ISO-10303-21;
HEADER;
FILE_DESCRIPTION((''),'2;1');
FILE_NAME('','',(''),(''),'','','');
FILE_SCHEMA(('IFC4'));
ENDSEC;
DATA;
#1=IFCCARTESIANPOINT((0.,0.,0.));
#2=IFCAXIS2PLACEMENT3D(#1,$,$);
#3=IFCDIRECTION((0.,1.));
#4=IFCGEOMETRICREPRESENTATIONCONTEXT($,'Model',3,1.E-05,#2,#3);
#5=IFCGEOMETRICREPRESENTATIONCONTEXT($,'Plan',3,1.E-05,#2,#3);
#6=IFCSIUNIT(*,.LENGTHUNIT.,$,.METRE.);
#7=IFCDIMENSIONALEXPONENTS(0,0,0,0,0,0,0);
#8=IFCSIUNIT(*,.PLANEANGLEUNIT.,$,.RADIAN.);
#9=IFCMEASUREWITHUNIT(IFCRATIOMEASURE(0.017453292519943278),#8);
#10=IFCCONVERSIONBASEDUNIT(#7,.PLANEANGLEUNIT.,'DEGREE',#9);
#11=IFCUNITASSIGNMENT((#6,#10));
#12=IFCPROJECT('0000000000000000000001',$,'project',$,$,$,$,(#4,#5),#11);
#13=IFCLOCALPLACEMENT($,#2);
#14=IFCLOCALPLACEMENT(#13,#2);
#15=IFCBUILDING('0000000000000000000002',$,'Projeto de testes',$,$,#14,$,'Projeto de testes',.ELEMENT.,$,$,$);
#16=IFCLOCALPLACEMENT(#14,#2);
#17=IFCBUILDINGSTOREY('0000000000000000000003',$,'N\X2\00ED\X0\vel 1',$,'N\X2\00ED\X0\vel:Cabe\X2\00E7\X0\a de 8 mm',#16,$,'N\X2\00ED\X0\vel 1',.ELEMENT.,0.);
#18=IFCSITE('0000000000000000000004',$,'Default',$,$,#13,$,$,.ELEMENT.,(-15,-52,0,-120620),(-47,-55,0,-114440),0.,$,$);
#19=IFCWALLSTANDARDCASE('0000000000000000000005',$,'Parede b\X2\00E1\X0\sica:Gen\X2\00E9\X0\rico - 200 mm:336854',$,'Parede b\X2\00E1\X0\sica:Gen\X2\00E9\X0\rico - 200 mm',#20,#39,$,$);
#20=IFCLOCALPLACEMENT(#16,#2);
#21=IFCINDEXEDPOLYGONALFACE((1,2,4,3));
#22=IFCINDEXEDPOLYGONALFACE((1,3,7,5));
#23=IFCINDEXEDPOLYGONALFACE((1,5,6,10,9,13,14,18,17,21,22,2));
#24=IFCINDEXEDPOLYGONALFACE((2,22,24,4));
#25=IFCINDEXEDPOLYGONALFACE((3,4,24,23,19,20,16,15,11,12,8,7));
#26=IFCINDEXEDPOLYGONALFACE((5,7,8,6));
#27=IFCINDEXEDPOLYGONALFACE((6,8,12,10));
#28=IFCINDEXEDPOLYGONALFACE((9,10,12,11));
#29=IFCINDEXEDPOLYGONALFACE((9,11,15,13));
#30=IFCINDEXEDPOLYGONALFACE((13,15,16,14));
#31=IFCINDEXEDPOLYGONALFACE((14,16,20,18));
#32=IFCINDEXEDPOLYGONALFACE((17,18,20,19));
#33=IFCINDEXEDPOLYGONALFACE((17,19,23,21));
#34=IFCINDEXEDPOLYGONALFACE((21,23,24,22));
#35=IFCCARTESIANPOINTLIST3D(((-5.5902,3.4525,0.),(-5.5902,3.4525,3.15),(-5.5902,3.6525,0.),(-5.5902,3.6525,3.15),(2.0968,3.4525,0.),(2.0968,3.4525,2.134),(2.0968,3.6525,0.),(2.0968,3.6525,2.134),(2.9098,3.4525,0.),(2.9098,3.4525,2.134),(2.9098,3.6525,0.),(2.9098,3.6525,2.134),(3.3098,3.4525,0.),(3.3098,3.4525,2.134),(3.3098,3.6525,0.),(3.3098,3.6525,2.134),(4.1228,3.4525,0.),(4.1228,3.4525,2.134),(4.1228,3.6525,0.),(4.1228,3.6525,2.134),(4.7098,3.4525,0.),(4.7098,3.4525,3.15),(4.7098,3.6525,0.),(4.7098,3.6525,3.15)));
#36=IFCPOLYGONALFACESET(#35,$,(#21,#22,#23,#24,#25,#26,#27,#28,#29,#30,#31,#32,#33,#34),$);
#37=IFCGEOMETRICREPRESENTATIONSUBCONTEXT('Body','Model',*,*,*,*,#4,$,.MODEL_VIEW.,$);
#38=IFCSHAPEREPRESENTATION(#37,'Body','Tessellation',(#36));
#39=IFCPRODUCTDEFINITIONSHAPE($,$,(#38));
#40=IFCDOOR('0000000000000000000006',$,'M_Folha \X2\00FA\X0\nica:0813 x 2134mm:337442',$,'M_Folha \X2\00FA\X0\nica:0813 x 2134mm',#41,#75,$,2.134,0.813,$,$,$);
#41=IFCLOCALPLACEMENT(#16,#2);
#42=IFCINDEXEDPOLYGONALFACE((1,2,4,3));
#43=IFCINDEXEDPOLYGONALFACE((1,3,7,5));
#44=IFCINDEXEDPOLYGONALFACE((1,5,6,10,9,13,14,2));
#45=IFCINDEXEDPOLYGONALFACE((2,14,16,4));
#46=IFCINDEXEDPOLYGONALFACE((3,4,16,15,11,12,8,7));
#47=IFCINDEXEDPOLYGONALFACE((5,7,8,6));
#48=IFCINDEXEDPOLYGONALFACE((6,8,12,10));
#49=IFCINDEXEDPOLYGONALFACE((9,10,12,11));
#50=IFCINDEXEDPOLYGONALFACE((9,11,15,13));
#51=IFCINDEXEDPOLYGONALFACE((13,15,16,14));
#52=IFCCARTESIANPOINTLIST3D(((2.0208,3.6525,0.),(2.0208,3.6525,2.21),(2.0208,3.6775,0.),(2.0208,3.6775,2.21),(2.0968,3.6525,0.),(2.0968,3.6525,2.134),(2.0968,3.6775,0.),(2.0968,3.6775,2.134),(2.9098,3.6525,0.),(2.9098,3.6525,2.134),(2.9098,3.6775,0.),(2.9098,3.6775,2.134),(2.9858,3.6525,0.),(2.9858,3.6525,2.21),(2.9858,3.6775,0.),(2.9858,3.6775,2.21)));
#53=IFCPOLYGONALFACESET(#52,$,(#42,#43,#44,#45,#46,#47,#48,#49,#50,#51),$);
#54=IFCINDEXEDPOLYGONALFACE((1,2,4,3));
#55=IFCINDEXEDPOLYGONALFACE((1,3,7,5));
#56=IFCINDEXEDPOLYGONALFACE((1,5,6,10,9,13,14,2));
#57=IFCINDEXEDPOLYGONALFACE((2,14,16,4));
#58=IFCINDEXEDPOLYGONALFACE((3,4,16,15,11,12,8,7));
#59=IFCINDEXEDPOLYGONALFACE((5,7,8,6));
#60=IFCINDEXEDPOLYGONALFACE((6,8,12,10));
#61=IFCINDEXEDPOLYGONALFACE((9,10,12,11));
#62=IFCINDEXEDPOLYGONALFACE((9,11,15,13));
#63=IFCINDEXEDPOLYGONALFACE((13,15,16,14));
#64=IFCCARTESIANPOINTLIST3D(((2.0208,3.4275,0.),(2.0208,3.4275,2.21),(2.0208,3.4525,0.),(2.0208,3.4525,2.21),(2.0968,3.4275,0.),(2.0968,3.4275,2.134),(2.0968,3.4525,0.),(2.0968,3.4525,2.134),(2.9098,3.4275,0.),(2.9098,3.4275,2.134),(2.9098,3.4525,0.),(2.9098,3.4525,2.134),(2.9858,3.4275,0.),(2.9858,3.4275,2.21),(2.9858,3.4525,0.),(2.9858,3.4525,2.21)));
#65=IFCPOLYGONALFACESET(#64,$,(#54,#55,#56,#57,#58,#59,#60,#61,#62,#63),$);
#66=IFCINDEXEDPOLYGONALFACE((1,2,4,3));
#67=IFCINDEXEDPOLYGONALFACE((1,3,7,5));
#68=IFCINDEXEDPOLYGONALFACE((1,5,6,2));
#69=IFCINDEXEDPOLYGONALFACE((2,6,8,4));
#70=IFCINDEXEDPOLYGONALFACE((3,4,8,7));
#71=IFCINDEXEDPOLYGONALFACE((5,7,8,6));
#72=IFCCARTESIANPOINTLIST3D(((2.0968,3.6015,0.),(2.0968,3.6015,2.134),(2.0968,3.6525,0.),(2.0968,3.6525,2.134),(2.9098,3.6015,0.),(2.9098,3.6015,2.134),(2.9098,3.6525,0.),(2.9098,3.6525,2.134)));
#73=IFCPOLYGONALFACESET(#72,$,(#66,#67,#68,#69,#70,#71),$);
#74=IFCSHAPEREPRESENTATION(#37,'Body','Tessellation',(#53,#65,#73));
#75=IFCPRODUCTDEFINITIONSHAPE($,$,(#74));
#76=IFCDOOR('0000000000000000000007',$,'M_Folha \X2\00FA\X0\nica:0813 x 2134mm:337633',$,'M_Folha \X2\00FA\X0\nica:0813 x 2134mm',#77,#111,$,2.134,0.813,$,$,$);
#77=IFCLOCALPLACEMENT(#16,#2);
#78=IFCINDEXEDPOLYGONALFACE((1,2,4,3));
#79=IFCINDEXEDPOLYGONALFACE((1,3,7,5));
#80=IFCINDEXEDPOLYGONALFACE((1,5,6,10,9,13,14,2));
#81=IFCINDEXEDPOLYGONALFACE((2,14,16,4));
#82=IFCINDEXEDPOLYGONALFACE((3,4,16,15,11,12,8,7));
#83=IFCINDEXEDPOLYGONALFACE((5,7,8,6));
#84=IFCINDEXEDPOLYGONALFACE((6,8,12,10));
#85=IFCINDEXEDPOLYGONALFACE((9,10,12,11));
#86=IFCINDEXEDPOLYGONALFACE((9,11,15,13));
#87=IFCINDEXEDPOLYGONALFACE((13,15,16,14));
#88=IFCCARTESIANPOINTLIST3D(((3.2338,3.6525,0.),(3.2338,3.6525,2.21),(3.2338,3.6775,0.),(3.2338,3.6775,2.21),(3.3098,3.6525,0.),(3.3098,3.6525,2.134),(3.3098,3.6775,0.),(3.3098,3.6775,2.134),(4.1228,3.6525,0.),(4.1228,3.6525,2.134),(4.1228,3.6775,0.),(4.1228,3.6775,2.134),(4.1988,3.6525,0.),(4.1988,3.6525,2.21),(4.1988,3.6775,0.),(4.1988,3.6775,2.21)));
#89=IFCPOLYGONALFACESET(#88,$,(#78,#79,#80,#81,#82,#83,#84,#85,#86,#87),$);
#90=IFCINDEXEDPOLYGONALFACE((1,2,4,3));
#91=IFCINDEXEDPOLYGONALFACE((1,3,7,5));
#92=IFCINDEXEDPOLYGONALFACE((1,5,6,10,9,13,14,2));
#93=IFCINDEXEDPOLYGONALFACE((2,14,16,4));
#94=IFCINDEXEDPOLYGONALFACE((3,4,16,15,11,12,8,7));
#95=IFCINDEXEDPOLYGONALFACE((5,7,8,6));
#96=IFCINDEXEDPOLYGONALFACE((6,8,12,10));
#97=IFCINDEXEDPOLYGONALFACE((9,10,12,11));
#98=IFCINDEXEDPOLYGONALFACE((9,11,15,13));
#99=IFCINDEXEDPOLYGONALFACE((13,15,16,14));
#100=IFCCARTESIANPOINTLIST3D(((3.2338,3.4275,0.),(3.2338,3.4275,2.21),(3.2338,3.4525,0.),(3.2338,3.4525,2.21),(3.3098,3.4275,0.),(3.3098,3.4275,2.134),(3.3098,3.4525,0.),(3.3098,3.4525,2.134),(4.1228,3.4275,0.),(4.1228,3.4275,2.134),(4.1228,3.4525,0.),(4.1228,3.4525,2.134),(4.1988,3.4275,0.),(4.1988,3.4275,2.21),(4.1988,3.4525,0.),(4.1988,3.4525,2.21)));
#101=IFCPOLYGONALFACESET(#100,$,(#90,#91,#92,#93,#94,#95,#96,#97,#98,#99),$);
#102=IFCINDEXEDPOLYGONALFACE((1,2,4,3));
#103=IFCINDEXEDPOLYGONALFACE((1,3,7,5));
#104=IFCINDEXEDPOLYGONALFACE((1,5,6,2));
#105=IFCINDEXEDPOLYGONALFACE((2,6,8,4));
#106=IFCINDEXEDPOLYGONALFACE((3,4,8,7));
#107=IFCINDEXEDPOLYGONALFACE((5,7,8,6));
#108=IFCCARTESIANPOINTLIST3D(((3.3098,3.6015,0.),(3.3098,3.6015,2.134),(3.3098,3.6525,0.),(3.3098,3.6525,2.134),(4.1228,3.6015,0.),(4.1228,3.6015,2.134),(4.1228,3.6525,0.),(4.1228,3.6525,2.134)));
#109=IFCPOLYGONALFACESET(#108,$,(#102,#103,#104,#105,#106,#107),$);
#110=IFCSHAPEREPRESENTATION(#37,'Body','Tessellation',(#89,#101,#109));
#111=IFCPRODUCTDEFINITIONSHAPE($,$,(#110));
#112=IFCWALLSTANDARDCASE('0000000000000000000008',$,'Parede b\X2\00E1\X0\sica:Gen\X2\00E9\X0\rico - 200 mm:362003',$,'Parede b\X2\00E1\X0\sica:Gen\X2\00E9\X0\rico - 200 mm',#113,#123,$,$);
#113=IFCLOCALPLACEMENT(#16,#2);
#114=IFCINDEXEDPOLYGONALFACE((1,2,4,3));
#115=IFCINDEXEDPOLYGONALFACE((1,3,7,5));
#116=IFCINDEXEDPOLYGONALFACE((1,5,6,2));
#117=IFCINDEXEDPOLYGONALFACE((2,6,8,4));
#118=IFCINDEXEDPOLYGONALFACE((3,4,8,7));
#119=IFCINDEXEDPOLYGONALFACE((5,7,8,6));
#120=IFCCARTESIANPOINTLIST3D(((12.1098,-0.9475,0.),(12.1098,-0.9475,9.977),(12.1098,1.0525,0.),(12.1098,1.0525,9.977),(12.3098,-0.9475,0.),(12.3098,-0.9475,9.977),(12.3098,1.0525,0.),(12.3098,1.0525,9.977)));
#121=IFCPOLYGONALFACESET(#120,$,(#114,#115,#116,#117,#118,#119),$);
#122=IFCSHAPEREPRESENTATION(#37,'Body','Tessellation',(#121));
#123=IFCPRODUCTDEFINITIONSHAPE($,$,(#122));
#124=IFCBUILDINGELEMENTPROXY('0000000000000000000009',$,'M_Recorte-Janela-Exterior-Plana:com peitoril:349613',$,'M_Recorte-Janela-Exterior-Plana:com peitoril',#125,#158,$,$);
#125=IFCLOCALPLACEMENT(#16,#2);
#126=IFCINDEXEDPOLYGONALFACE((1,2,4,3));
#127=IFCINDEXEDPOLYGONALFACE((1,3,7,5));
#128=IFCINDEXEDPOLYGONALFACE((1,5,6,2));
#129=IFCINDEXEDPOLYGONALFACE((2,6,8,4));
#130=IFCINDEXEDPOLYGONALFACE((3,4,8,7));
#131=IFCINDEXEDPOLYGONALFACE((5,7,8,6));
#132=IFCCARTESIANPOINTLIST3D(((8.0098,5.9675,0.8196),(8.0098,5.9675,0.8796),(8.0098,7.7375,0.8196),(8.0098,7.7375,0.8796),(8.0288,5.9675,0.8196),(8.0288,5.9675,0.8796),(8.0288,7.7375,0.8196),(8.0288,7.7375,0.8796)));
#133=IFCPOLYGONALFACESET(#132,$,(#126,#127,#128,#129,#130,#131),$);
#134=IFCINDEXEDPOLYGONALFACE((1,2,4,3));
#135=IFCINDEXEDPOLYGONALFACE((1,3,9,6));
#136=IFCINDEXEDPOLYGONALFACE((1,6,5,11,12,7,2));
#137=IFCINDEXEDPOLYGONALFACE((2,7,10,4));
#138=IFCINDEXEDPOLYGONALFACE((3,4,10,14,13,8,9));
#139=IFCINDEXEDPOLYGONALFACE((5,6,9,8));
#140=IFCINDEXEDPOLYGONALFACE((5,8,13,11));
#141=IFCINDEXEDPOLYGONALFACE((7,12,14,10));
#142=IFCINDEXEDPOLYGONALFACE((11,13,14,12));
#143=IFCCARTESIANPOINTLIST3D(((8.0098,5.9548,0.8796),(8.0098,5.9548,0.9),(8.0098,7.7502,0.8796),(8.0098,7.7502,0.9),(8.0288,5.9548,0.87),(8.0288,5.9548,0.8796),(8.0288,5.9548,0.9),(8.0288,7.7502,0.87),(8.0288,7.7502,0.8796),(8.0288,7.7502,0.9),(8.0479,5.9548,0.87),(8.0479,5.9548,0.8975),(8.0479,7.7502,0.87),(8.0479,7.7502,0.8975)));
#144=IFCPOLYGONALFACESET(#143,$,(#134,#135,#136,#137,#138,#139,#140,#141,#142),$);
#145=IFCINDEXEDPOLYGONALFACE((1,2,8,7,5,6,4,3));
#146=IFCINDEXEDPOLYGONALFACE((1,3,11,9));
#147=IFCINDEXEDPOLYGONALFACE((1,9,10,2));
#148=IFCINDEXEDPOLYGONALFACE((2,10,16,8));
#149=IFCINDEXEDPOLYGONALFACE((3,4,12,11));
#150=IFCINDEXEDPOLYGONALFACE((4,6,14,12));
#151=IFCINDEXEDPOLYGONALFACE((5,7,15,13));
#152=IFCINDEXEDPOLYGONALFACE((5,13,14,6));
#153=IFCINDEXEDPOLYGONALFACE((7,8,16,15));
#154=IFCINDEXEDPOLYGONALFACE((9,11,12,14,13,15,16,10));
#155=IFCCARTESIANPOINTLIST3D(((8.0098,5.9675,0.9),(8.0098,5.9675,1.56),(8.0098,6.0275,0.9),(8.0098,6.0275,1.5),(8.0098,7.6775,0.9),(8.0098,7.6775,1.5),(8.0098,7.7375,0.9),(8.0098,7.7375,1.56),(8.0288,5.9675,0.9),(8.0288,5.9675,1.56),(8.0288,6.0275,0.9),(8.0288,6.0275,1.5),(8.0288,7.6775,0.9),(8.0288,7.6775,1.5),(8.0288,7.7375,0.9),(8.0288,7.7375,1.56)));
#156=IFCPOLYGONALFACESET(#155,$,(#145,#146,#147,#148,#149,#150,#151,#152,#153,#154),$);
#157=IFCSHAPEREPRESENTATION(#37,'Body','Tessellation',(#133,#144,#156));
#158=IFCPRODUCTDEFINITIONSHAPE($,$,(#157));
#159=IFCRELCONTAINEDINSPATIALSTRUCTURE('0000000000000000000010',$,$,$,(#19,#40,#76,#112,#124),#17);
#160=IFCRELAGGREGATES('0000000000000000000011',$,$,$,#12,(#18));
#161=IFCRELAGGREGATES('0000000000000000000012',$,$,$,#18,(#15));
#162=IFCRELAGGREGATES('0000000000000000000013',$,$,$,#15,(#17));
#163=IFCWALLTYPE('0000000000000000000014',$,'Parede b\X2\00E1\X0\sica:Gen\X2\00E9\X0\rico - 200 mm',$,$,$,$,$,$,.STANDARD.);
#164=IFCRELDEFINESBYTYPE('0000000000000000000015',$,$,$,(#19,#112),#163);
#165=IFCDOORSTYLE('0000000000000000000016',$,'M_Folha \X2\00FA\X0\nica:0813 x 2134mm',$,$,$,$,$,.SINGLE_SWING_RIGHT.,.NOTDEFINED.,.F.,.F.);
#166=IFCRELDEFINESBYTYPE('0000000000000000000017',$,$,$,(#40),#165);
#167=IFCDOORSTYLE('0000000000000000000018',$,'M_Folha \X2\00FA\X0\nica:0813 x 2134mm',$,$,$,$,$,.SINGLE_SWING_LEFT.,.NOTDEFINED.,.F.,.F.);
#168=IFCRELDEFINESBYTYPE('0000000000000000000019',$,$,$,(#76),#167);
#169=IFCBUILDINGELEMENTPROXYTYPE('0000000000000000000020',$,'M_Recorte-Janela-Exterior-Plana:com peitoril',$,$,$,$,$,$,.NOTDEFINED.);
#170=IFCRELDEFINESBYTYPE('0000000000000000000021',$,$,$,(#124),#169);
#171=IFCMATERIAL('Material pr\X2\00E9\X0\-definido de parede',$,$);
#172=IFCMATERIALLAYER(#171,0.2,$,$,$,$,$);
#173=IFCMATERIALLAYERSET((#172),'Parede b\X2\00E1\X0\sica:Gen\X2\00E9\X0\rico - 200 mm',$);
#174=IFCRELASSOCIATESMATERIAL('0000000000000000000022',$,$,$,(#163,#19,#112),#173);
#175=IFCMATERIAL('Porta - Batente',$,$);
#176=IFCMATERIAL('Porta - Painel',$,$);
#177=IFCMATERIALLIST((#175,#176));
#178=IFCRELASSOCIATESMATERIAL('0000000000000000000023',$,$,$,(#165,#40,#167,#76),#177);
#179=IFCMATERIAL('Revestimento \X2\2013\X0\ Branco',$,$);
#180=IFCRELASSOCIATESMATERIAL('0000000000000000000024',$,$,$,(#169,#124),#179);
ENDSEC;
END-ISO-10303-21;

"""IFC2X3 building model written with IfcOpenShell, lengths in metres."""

from ifc_helpers import new_model, entity, si_unit, converted_unit, direction, frame, frame_2d, origin, place, context, subcontext, project, spatial, polyline, rectangle, outline, extrude, source, transform, mapped, material, material_list, layer, layer_set, layer_usage, type_object, type_shapes, element, fill, save


model = new_model("IFC2X3")

# Units and contexts
model_context = context("Model", 3, precision=1e-05, world=origin(), true_north=direction((0.0, 1.0)))
plan_context = context("Plan", 3, precision=1e-05, world=origin(), true_north=direction((0.0, 1.0)))
body_context = subcontext(model_context, "Body", "Model", "MODEL_VIEW")
ifc_project = project(units=[si_unit("LENGTHUNIT", "METRE"), converted_unit("PLANEANGLEUNIT", "DEGREE", entity("IfcRatioMeasure", 0.017453292519943278), si_unit("PLANEANGLEUNIT", "RADIAN"), dimensions=[0, 0, 0, 0, 0, 0, 0])], contexts=[model_context, plan_context])

# Site, building, storey
site_placement = place(None, origin())
site = spatial("IfcSite", under=ifc_project, at=site_placement, Name="Default", CompositionType="ELEMENT", RefLatitude=(-15, -52, 0, -120620), RefLongitude=(-47, -55, 0, -114440), RefElevation=0.0)
building_placement = place(site_placement, origin())
building = spatial("IfcBuilding", under=site, at=building_placement, Name="Projeto de testes", LongName="Projeto de testes", CompositionType="ELEMENT")
storey_placement = place(building_placement, origin())
storey = spatial("IfcBuildingStorey", under=building, at=storey_placement, Name="Nível 1", ObjectType="Nível:Cabeça de 8 mm", LongName="Nível 1", CompositionType="ELEMENT", Elevation=0.0)

# Shared definitions
ifc_material_1 = material(Name="Material pré-definido de parede")
ifc_layer = layer(ifc_material_1, 0.2)
ifc_layer_set = layer_set([ifc_layer], Name="Parede básica:Genérico - 200 mm")
ifc_layer_usage_1 = layer_usage(ifc_layer_set, "AXIS2", "POSITIVE", -0.1)
wall_type = type_object("IfcWallType", Name="Parede básica:Genérico - 200 mm", PredefinedType="STANDARD", material=ifc_layer_set)

# Shared definitions
ifc_material_2 = material(Name="Porta - Batente")
ifc_material_3 = material(Name="Porta - Painel")
ifc_material_list_1 = material_list([ifc_material_2, ifc_material_3])

# Shared definitions
ifc_layer_usage_2 = layer_usage(ifc_layer_set, "AXIS2", "NEGATIVE", 0.1)

# Shared definitions
door_style_1 = type_object("IfcDoorStyle", Name="M_Folha única:0813 x 2134mm", ConstructionType="NOTDEFINED", OperationType="SINGLE_SWING_RIGHT", ParameterTakesPrecedence=False, Sizeable=False, material=ifc_material_list_1)
shared_shape_1 = source(origin(), body_context, "Body", "SweptSolid", [
    extrude(outline(polyline([(-0.4825, -1.124), (0.4825, -1.124), (0.4825, 1.086), (0.4065, 1.086), (0.4065, -1.048), (-0.4065, -1.048), (-0.4065, 1.086), (-0.4825, 1.086), (-0.4825, -1.124)])), frame((0.4065, 0.2, 1.086), z_axis=(0.0, 1.0, 0.0), x_axis=(1.0, 0.0, 0.0)), (0.0, 0.0, 1.0), 0.025),
    extrude(outline(polyline([(-1.124, -0.4825), (1.086, -0.4825), (1.086, -0.4065), (-1.048, -0.4065), (-1.048, 0.4065), (1.086, 0.4065), (1.086, 0.4825), (-1.124, 0.4825), (-1.124, -0.4825)])), frame((0.4065, -0.025, 1.086), z_axis=(0.0, 1.0, 0.0), x_axis=(0.0, 0.0, -1.0)), (0.0, 0.0, 1.0), 0.025),
    extrude(rectangle(XDim=0.051, YDim=0.813, at=frame_2d((0.0, 0.0), x_axis=(1.0, 0.0))), frame((0.4065, 0.1745, 0.0), z_axis=(0.0, 0.0, 1.0), x_axis=(0.0, 1.0, 0.0)), (0.0, 0.0, 1.0), 2.134),
])
type_shapes(door_style_1, [shared_shape_1])

# Wall, openings, doors
wall_1_placement = place(storey_placement, frame((4.7098, 3.5525, 0.0), z_axis=(0.0, 0.0, 1.0), x_axis=(-1.0, 0.0, 0.0)))
wall_1 = element("IfcWallStandardCase", 1, at=wall_1_placement, inside=storey, type_object=wall_type, material=ifc_layer_usage_1, Name="Parede básica:Genérico - 200 mm:336854", ObjectType="Parede básica:Genérico - 200 mm", context=body_context, shape_type="SweptSolid", body=[
    extrude(rectangle(XDim=10.3, YDim=0.2, at=frame_2d((5.15, 0.0), x_axis=(1.0, 0.0))), origin(), (0.0, 0.0, 1.0), 3.15),
])
opening_1_placement = place(wall_1_placement, frame((2.613, 0.1, 0.0)))
opening_1 = element("IfcOpeningElement", 2, at=opening_1_placement, cuts=wall_1, ObjectType="Opening", context=body_context, shape_type="SweptSolid", body=[
    extrude(rectangle(XDim=0.813, YDim=2.134, at=frame_2d((1.067, 0.4065), x_axis=(0.0, 1.0))), frame((0.0, 0.0, 0.0), z_axis=(0.0, -1.0, 0.0), x_axis=(0.0, 0.0, 1.0)), (0.0, 0.0, 1.0), 0.2),
])
opening_2_placement = place(wall_1_placement, frame((1.4, 0.1, 0.0)))
opening_2 = element("IfcOpeningElement", 3, at=opening_2_placement, cuts=wall_1, ObjectType="Opening", context=body_context, shape_type="SweptSolid", body=[
    extrude(rectangle(XDim=0.813, YDim=2.134, at=frame_2d((1.067, 0.4065), x_axis=(0.0, -1.0))), frame((0.0, 0.0, 0.0), z_axis=(0.0, -1.0, 0.0), x_axis=(0.0, 0.0, 1.0)), (0.0, 0.0, 1.0), 0.2),
])
door_1_placement = place(opening_1_placement, frame((0.0, 0.0, 0.0), z_axis=(0.0, 0.0, 1.0), x_axis=(-1.0, 0.0, 0.0)))
door_1 = element("IfcDoor", 4, at=door_1_placement, inside=storey, type_object=door_style_1, material=ifc_material_list_1, Name="M_Folha única:0813 x 2134mm:337442", ObjectType="M_Folha única:0813 x 2134mm", OverallHeight=2.134, OverallWidth=0.813, context=body_context, shape_type="MappedRepresentation", body=[
    mapped(shared_shape_1, transform((0.0, 0.0, 0.0), scale=1.0)),
])
fill(opening_1, door_1)
door_style_2 = type_object("IfcDoorStyle", Name="M_Folha única:0813 x 2134mm", ConstructionType="NOTDEFINED", OperationType="SINGLE_SWING_LEFT", ParameterTakesPrecedence=False, Sizeable=False, material=ifc_material_list_1)
shared_shape_2 = source(origin(), body_context, "Body", "SweptSolid", [
    extrude(outline(polyline([(-0.4825, -1.124), (0.4825, -1.124), (0.4825, 1.086), (0.4065, 1.086), (0.4065, -1.048), (-0.4065, -1.048), (-0.4065, 1.086), (-0.4825, 1.086), (-0.4825, -1.124)])), frame((0.4065, 0.225, 1.086), z_axis=(0.0, -1.0, 0.0), x_axis=(-1.0, 0.0, 0.0)), (0.0, 0.0, 1.0), 0.025),
    extrude(outline(polyline([(-1.124, -0.4825), (1.086, -0.4825), (1.086, -0.4065), (-1.048, -0.4065), (-1.048, 0.4065), (1.086, 0.4065), (1.086, 0.4825), (-1.124, 0.4825), (-1.124, -0.4825)])), frame((0.4065, 0.0, 1.086), z_axis=(0.0, -1.0, 0.0), x_axis=(0.0, 0.0, -1.0)), (0.0, 0.0, 1.0), 0.025),
    extrude(rectangle(XDim=0.813, YDim=0.051, at=frame_2d((0.0, 0.0), x_axis=(1.0, 0.0))), frame((0.4065, 0.1745, 0.0)), (0.0, 0.0, 1.0), 2.134),
])
type_shapes(door_style_2, [shared_shape_2])
door_2_placement = place(opening_2_placement, frame((0.0, 0.0, 0.0), z_axis=(0.0, 0.0, 1.0), x_axis=(-1.0, 0.0, 0.0)))
door_2 = element("IfcDoor", 5, at=door_2_placement, inside=storey, type_object=door_style_2, material=ifc_material_list_1, Name="M_Folha única:0813 x 2134mm:337633", ObjectType="M_Folha única:0813 x 2134mm", OverallHeight=2.134, OverallWidth=0.813, context=body_context, shape_type="MappedRepresentation", body=[
    mapped(shared_shape_2, transform((0.0, 0.0, 0.0), scale=1.0)),
])
fill(opening_2, door_2)

# Wall
wall_2_placement = place(storey_placement, frame((12.2098, -0.9475, 0.0), z_axis=(0.0, 0.0, 1.0), x_axis=(0.0, 1.0, 0.0)))
element("IfcWallStandardCase", 6, at=wall_2_placement, inside=storey, type_object=wall_type, material=ifc_layer_usage_2, Name="Parede básica:Genérico - 200 mm:362003", ObjectType="Parede básica:Genérico - 200 mm", context=body_context, shape_type="SweptSolid", body=[
    extrude(rectangle(XDim=2.0, YDim=0.2, at=frame_2d((1.0, 0.0), x_axis=(-1.0, 0.0))), origin(), (0.0, 0.0, 1.0), 9.977),
])

# Building element proxy
ifc_material_4 = material(Name="Revestimento – Branco")
building_element_proxy_type_1 = type_object("IfcBuildingElementProxyType", Name="M_Recorte-Janela-Exterior-Plana:com peitoril", PredefinedType="NOTDEFINED", material=ifc_material_4)
shared_shape_3 = source(origin(), body_context, "Body", "SweptSolid", [
    extrude(rectangle(XDim=1.77, YDim=0.06, at=frame_2d((0.0, 0.0), x_axis=(1.0, 0.0))), frame((0.0, -0.6504, 0.0), z_axis=(0.0, 0.0, 1.0), x_axis=(-1.0, 0.0, 0.0)), (0.0, 0.0, 1.0), 0.019),
    extrude(outline(polyline([(-0.019, -0.0152), (0.0, -0.0152), (0.0, -0.0057), (0.019, -0.0057), (0.019, 0.0148), (0.0, 0.0148), (-0.019, 0.0123), (-0.019, -0.0152)])), frame((-0.8977, -0.6148, 0.019), z_axis=(1.0, 0.0, 0.0), x_axis=(0.0, 0.0, -1.0)), (0.0, 0.0, 1.0), 1.7954),
    extrude(outline(polyline([(-0.345, -0.885), (0.315, -0.885), (0.315, -0.825), (-0.285, -0.825), (-0.285, 0.825), (0.315, 0.825), (0.315, 0.885), (-0.345, 0.885), (-0.345, -0.885)])), frame((0.0, -0.285, 0.0), z_axis=(0.0, 0.0, 1.0), x_axis=(0.0, -1.0, 0.0)), (0.0, 0.0, 1.0), 0.019),
])
type_shapes(building_element_proxy_type_1, [shared_shape_3])
proxy_1_placement = place(storey_placement, frame((8.0098, 6.8525, 1.5), z_axis=(1.0, 0.0, 0.0), x_axis=(0.0, 1.0, 0.0)))
element("IfcBuildingElementProxy", 7, at=proxy_1_placement, inside=storey, type_object=building_element_proxy_type_1, material=ifc_material_4, Name="M_Recorte-Janela-Exterior-Plana:com peitoril:349613", ObjectType="M_Recorte-Janela-Exterior-Plana:com peitoril", context=body_context, shape_type="MappedRepresentation", body=[
    mapped(shared_shape_3, transform((0.0, 0.0, 0.0), scale=1.0)),
])

save(model, "model.ifc")
